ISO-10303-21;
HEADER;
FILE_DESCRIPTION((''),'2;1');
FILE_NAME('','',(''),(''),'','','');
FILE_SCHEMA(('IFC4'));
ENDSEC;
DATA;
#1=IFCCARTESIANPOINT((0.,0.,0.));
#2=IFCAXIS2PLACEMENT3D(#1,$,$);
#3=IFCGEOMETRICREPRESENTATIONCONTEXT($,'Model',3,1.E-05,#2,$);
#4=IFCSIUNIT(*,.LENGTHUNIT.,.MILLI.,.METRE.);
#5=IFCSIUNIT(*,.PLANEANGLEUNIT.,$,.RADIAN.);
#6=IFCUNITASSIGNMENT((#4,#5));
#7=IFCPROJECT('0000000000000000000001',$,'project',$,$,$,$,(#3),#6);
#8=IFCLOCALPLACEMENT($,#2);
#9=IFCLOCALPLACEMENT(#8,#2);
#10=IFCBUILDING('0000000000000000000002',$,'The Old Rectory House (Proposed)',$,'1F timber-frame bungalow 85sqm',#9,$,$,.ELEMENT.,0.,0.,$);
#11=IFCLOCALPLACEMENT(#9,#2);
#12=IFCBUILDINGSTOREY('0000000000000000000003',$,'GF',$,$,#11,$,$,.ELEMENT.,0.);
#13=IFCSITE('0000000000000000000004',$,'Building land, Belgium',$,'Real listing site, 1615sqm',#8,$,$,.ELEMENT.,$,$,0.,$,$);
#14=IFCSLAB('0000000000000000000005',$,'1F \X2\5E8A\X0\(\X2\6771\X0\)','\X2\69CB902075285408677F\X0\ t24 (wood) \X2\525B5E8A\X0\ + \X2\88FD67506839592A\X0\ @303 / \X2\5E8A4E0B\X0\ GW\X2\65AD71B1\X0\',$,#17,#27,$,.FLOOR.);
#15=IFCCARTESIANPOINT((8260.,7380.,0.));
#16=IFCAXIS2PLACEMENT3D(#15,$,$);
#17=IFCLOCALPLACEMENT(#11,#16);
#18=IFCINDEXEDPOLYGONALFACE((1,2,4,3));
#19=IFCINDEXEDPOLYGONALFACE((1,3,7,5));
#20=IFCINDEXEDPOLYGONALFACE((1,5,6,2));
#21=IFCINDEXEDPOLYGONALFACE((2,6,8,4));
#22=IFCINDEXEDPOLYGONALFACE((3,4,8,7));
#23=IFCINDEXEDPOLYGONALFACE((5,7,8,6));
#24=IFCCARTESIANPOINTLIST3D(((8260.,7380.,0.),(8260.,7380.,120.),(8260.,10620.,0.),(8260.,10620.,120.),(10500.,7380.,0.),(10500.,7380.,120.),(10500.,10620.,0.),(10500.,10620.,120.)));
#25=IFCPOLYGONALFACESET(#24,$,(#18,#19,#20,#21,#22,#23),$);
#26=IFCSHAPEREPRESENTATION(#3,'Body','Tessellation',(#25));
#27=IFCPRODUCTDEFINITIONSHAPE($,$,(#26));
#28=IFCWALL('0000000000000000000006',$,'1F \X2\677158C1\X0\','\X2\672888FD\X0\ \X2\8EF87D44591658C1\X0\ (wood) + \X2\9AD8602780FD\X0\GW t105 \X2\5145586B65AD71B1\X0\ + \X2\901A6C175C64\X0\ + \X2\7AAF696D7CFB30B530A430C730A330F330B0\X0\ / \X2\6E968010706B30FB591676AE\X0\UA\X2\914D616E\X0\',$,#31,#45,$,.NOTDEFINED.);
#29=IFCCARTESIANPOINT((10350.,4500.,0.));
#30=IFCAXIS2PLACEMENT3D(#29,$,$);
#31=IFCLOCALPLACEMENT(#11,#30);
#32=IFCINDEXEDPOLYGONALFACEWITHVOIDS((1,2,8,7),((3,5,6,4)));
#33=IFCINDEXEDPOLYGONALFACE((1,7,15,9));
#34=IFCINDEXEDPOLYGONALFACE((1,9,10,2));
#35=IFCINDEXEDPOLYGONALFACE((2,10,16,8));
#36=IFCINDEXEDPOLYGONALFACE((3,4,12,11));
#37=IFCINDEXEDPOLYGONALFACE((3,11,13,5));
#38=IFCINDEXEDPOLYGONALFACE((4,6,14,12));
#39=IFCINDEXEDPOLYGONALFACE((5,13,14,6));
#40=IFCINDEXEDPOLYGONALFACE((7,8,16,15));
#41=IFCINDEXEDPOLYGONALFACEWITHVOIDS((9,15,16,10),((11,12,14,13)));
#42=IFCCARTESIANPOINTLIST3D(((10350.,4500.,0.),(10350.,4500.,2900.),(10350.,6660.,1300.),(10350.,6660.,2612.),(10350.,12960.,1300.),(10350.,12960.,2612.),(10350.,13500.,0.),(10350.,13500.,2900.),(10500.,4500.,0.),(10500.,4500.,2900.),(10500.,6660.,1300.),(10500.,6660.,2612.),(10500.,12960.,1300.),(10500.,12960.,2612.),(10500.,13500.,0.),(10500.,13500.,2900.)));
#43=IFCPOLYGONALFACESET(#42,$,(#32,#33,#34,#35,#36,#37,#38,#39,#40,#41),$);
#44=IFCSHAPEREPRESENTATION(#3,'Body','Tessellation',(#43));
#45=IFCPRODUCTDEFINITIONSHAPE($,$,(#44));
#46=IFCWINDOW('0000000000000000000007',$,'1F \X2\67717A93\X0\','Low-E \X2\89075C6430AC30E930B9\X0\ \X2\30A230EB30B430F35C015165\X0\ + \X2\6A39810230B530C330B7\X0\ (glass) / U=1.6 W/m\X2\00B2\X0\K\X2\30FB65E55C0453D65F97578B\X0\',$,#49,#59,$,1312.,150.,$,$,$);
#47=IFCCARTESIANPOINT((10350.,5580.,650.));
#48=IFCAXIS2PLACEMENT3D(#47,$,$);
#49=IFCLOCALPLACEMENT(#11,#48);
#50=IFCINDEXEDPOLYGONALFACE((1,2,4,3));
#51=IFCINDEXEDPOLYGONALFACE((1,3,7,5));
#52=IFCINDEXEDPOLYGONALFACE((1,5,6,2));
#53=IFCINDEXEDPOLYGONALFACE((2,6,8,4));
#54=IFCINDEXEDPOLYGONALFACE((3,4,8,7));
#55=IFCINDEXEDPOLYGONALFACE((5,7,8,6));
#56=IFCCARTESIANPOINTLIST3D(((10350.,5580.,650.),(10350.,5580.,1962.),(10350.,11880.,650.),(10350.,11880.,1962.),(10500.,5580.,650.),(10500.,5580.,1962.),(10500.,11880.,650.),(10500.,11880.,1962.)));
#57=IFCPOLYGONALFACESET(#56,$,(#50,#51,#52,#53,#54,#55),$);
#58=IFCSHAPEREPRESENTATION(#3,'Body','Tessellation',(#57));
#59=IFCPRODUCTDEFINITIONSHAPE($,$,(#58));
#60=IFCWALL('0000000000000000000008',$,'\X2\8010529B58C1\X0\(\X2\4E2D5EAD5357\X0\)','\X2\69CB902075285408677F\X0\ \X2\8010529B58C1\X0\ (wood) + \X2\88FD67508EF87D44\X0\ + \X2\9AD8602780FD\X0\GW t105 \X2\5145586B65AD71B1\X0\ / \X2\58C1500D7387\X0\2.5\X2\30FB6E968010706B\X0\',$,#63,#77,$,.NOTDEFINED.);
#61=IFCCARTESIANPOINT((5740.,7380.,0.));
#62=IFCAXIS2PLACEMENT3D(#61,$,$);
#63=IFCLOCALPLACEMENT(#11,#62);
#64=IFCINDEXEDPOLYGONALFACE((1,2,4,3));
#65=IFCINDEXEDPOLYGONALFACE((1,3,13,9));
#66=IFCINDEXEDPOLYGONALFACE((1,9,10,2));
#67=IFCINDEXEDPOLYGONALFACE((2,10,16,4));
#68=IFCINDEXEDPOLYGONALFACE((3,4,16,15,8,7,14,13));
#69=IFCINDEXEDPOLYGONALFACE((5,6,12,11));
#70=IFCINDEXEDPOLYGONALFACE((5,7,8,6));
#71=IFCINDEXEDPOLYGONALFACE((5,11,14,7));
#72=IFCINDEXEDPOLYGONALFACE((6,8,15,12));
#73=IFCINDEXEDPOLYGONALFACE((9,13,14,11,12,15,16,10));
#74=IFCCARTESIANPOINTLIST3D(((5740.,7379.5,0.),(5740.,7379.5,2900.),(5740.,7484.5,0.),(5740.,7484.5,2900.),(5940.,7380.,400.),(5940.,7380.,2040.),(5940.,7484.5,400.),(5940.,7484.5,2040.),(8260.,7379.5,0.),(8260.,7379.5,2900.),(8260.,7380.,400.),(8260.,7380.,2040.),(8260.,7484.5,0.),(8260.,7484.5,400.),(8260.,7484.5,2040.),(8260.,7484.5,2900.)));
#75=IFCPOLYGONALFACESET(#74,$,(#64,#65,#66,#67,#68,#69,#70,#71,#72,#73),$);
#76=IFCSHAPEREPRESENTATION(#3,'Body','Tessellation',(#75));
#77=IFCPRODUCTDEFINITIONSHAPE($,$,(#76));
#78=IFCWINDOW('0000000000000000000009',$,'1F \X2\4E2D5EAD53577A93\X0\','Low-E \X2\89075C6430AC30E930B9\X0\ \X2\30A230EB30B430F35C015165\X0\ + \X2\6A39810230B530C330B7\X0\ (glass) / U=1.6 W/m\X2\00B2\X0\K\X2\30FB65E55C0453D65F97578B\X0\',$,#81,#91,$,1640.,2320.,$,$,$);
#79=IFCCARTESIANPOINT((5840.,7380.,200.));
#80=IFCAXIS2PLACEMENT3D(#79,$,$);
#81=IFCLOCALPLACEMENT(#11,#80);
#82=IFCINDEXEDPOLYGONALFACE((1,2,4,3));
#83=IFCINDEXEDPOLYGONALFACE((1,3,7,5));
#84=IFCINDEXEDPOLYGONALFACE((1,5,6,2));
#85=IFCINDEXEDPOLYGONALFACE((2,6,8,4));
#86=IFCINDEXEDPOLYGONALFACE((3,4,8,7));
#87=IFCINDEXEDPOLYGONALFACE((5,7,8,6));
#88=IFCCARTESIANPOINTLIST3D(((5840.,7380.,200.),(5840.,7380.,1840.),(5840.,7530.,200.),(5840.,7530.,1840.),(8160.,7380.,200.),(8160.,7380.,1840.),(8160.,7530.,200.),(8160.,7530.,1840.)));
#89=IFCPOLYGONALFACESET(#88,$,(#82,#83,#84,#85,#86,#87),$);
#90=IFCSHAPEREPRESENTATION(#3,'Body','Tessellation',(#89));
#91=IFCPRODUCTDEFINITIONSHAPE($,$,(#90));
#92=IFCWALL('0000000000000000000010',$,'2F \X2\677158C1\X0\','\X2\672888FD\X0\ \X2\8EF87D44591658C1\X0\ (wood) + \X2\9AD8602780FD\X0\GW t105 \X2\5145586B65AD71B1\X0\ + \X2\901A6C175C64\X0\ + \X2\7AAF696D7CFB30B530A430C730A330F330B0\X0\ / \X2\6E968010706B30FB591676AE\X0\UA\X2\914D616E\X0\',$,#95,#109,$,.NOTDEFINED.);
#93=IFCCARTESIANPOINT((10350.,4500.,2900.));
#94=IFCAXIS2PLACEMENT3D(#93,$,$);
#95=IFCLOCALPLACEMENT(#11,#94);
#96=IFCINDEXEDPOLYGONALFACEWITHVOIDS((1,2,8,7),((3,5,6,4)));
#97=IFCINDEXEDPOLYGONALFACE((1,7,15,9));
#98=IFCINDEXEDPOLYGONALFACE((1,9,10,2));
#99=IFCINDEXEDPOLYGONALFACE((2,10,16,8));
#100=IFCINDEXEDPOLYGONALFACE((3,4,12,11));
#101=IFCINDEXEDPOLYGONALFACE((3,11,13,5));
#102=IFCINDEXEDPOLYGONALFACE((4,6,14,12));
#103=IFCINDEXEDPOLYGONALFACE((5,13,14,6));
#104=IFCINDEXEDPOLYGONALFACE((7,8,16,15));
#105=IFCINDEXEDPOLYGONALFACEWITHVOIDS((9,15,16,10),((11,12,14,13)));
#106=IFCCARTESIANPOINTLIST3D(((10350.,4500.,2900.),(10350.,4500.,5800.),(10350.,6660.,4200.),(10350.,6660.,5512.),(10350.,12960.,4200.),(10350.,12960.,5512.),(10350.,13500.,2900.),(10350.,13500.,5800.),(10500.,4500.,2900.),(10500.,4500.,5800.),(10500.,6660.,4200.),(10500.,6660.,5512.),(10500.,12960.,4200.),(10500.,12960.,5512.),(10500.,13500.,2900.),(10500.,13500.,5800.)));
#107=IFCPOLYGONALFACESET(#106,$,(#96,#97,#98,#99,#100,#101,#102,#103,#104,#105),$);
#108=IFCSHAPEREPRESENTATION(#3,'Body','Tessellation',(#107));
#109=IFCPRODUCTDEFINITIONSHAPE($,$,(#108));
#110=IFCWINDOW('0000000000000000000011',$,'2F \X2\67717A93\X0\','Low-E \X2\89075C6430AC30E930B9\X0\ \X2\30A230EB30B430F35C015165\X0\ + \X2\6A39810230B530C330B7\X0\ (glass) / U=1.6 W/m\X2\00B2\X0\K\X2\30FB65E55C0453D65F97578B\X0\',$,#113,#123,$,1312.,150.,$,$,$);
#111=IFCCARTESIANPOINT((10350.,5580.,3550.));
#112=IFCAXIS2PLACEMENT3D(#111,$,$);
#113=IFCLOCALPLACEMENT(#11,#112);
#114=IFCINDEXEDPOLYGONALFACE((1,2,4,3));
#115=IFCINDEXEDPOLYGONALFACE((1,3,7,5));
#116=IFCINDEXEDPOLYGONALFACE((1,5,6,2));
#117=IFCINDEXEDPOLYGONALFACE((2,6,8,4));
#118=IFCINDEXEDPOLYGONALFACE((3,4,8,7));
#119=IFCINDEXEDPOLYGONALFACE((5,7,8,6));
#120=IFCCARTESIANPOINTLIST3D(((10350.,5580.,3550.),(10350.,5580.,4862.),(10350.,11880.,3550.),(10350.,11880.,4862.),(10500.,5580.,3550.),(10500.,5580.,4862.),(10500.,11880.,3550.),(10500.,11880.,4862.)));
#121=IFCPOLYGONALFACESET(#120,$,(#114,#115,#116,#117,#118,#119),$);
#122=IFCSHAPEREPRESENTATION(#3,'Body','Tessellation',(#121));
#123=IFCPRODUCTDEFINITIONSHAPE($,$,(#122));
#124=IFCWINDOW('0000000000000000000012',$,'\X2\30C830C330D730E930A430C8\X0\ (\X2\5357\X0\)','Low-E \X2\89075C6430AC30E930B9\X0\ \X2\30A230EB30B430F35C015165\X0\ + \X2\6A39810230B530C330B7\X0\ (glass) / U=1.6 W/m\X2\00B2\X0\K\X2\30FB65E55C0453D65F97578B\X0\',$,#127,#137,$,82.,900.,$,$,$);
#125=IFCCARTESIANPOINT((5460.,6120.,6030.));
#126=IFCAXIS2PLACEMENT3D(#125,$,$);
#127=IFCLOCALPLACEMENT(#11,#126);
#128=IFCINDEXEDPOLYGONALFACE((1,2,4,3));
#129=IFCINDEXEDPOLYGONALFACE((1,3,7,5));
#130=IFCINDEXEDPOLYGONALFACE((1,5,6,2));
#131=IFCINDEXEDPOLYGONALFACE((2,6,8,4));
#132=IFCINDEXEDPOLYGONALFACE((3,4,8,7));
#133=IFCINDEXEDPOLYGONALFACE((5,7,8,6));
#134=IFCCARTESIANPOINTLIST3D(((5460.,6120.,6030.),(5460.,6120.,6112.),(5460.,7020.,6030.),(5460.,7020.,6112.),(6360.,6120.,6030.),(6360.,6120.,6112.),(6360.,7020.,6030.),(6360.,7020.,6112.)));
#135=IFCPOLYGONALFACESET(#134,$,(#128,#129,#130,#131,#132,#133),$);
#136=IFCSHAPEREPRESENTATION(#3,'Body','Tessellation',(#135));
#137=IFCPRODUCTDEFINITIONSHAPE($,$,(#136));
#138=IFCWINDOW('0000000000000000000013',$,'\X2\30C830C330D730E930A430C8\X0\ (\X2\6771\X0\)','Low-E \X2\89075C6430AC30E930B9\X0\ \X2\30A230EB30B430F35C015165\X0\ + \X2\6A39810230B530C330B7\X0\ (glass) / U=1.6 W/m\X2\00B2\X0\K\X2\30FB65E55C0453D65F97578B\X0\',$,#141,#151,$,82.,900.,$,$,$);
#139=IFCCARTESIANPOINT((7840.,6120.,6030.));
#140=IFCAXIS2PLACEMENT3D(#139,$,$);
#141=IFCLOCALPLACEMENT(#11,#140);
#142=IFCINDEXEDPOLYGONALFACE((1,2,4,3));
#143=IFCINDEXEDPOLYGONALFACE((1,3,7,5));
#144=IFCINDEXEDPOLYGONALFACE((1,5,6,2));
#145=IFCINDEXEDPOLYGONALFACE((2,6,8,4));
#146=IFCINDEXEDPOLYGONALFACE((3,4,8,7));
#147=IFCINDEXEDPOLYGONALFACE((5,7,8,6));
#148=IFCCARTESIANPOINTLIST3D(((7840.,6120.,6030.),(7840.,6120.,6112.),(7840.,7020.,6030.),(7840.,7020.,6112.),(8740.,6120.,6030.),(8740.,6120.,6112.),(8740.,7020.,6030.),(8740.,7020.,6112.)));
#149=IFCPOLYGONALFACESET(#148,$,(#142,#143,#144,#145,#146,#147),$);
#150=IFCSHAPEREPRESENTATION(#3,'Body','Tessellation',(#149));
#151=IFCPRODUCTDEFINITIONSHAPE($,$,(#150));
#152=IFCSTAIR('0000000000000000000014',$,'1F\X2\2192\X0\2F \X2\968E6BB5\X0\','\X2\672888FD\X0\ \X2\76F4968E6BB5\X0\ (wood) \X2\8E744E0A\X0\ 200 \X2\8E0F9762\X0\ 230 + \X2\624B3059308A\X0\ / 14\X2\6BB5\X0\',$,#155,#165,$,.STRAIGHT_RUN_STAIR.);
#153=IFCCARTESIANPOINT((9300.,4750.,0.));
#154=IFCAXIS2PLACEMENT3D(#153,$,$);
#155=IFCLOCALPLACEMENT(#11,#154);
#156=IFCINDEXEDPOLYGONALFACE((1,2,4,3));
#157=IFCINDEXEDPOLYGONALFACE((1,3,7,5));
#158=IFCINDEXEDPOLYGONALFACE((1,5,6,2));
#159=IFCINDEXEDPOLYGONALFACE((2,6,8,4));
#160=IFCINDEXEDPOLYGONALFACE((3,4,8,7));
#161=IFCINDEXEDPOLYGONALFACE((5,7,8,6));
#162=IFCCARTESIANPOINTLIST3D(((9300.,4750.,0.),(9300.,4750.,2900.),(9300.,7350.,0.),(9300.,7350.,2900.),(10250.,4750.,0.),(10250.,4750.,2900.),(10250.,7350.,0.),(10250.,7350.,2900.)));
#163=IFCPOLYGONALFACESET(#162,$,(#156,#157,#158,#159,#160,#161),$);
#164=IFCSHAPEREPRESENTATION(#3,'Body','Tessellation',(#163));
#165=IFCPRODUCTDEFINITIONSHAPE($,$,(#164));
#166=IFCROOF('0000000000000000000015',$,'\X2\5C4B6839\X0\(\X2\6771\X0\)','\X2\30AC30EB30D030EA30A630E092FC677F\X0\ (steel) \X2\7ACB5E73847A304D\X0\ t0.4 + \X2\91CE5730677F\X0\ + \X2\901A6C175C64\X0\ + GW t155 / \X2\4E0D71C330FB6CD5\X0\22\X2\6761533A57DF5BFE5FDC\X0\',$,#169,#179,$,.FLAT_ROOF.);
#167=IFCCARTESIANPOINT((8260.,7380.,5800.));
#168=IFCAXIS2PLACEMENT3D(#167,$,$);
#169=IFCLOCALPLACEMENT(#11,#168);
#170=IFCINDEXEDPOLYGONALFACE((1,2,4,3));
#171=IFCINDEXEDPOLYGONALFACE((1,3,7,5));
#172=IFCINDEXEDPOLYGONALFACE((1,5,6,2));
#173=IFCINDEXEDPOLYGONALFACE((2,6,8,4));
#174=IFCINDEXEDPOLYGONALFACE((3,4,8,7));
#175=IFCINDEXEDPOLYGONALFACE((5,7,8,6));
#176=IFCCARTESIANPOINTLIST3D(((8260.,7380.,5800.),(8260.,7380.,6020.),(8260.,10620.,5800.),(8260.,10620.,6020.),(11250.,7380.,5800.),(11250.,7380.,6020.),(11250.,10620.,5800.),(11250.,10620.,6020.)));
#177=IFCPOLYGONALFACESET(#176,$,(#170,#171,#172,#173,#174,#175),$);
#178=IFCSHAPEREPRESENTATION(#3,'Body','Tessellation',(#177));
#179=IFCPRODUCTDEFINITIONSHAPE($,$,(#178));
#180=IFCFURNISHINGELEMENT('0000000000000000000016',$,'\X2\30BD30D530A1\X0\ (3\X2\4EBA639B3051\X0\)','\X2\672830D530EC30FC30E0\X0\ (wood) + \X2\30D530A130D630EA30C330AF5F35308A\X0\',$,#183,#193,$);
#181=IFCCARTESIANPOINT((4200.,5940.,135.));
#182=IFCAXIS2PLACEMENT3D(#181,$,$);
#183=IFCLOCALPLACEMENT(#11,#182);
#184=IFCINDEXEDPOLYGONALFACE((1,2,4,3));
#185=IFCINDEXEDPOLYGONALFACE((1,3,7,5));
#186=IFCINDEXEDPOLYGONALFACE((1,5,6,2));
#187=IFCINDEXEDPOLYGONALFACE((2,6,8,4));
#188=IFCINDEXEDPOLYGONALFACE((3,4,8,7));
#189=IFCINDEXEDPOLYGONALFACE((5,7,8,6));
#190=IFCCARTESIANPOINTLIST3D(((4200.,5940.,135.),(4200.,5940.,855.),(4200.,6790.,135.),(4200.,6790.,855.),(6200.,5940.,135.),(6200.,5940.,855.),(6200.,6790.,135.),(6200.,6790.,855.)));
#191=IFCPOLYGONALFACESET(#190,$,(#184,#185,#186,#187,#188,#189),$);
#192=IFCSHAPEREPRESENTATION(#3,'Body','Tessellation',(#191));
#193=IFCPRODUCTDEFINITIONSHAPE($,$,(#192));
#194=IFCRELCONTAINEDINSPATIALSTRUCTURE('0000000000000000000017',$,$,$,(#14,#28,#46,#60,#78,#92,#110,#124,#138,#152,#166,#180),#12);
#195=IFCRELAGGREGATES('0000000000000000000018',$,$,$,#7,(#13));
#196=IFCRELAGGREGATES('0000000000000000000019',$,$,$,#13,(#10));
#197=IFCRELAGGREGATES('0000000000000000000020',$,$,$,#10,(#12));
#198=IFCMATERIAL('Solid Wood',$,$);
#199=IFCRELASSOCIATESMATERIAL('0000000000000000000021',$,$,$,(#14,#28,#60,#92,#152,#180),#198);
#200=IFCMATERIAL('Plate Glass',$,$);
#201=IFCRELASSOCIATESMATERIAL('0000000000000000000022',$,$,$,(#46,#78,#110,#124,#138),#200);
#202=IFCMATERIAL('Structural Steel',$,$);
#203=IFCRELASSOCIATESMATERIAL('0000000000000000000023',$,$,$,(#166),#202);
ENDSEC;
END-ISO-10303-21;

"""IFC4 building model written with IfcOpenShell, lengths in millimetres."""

from ifc_helpers import new_model, si_unit, frame, frame_2d, origin, place, context, project, spatial, rectangle, extrude, material, element, fill, save


model = new_model("IFC4")

# Units and contexts
model_context = context("Model", 3, precision=1e-05, world=origin())
ifc_project = project(units=[si_unit("LENGTHUNIT", "METRE", prefix="MILLI"), si_unit("PLANEANGLEUNIT", "RADIAN")], contexts=[model_context])

# Site, building, storey
site_placement = place(None, origin())
site = spatial("IfcSite", under=ifc_project, at=site_placement, Name="Building land, Belgium", ObjectType="Real listing site, 1615sqm", CompositionType="ELEMENT", RefElevation=0.0)
building_placement = place(site_placement, origin())
building = spatial("IfcBuilding", under=site, at=building_placement, Name="The Old Rectory House (Proposed)", ObjectType="1F timber-frame bungalow 85sqm", CompositionType="ELEMENT", ElevationOfRefHeight=0.0, ElevationOfTerrain=0.0)
storey_placement = place(building_placement, origin())
storey = spatial("IfcBuildingStorey", under=building, at=storey_placement, Name="GF", CompositionType="ELEMENT", Elevation=0.0)

# Slab
ifc_material_1 = material(Name="Solid Wood")
slab_placement = place(storey_placement, frame((8260.0, 7380.0, 0.0)))
element("IfcSlab", 1, at=slab_placement, inside=storey, material=ifc_material_1, Name="1F 床(東)", Description="構造用合板 t24 (wood) 剛床 + 製材根太 @303 / 床下 GW断熱", PredefinedType="FLOOR", context=model_context, shape_type="SweptSolid", body=[
    extrude(rectangle(XDim=2240.0, YDim=3240.0, at=frame_2d((1120.0, 1620.0))), frame((8260.0, 7380.0, 0.0)), (0.0, 0.0, 1.0), 120.0),
])

# Walls, openings, windows
wall_1_placement = place(storey_placement, frame((10350.0, 4500.0, 0.0)))
wall_1 = element("IfcWall", 2, at=wall_1_placement, inside=storey, material=ifc_material_1, Name="1F 東壁", Description="木製 軸組外壁 (wood) + 高性能GW t105 充填断熱 + 通気層 + 窯業系サイディング / 準耐火・外皮UA配慮", PredefinedType="NOTDEFINED", context=model_context, shape_type="SweptSolid", body=[
    extrude(rectangle(XDim=150.0, YDim=9000.0, at=frame_2d((75.0, 4500.0))), frame((10350.0, 4500.0, 0.0)), (0.0, 0.0, 1.0), 2900.0),
])
opening_1_placement = place(storey_placement, frame((10350.0, 5580.0, 650.0)))
opening_1 = element("IfcOpeningElement", 3, at=opening_1_placement, cuts=wall_1, PredefinedType="NOTDEFINED", context=model_context, shape_type="SweptSolid", body=[
    extrude(rectangle(XDim=150.0, YDim=6300.0, at=frame_2d((75.0, 3150.0))), frame((10350.0, 5580.0, 650.0)), (0.0, 0.0, 1.0), 1312.0),
])
ifc_material_2 = material(Name="Plate Glass")
window_1_placement = place(storey_placement, frame((10350.0, 5580.0, 650.0)))
window_1 = element("IfcWindow", 4, at=window_1_placement, inside=storey, material=ifc_material_2, Name="1F 東窓", Description="Low-E 複層ガラス アルゴン封入 + 樹脂サッシ (glass) / U=1.6 W/m²K・日射取得型", OverallHeight=1312.0, OverallWidth=150.0, context=model_context, shape_type="SweptSolid", body=[
    extrude(rectangle(XDim=150.0, YDim=6300.0, at=frame_2d((75.0, 3150.0))), frame((10350.0, 5580.0, 650.0)), (0.0, 0.0, 1.0), 1312.0),
])
fill(opening_1, window_1)
wall_2_placement = place(storey_placement, frame((5740.0, 7380.0, 0.0)))
wall_2 = element("IfcWall", 5, at=wall_2_placement, inside=storey, material=ifc_material_1, Name="耐力壁(中庭南)", Description="構造用合板 耐力壁 (wood) + 製材軸組 + 高性能GW t105 充填断熱 / 壁倍率2.5・準耐火", PredefinedType="NOTDEFINED", context=model_context, shape_type="SweptSolid", body=[
    extrude(rectangle(XDim=2520.0, YDim=105.0, at=frame_2d((1260.0, 52.0))), frame((5740.0, 7380.0, 0.0)), (0.0, 0.0, 1.0), 2900.0),
])
opening_2_placement = place(storey_placement, frame((5840.0, 7380.0, 200.0)))
opening_2 = element("IfcOpeningElement", 6, at=opening_2_placement, cuts=wall_2, PredefinedType="NOTDEFINED", context=model_context, shape_type="SweptSolid", body=[
    extrude(rectangle(XDim=2320.0, YDim=150.0, at=frame_2d((1160.0, 75.0))), frame((5840.0, 7380.0, 200.0)), (0.0, 0.0, 1.0), 1640.0),
])
window_2_placement = place(storey_placement, frame((5840.0, 7380.0, 200.0)))
window_2 = element("IfcWindow", 7, at=window_2_placement, inside=storey, material=ifc_material_2, Name="1F 中庭南窓", Description="Low-E 複層ガラス アルゴン封入 + 樹脂サッシ (glass) / U=1.6 W/m²K・日射取得型", OverallHeight=1640.0, OverallWidth=2320.0, context=model_context, shape_type="SweptSolid", body=[
    extrude(rectangle(XDim=2320.0, YDim=150.0, at=frame_2d((1160.0, 75.0))), frame((5840.0, 7380.0, 200.0)), (0.0, 0.0, 1.0), 1640.0),
])
fill(opening_2, window_2)

# Wall, opening, window
wall_3_placement = place(storey_placement, frame((10350.0, 4500.0, 2900.0)))
wall_3 = element("IfcWall", 8, at=wall_3_placement, inside=storey, material=ifc_material_1, Name="2F 東壁", Description="木製 軸組外壁 (wood) + 高性能GW t105 充填断熱 + 通気層 + 窯業系サイディング / 準耐火・外皮UA配慮", PredefinedType="NOTDEFINED", context=model_context, shape_type="SweptSolid", body=[
    extrude(rectangle(XDim=150.0, YDim=9000.0, at=frame_2d((75.0, 4500.0))), frame((10350.0, 4500.0, 2900.0)), (0.0, 0.0, 1.0), 2900.0),
])
opening_3_placement = place(storey_placement, frame((10350.0, 5580.0, 3550.0)))
opening_3 = element("IfcOpeningElement", 9, at=opening_3_placement, cuts=wall_3, PredefinedType="NOTDEFINED", context=model_context, shape_type="SweptSolid", body=[
    extrude(rectangle(XDim=150.0, YDim=6300.0, at=frame_2d((75.0, 3150.0))), frame((10350.0, 5580.0, 3550.0)), (0.0, 0.0, 1.0), 1312.0),
])
window_3_placement = place(storey_placement, frame((10350.0, 5580.0, 3550.0)))
window_3 = element("IfcWindow", 10, at=window_3_placement, inside=storey, material=ifc_material_2, Name="2F 東窓", Description="Low-E 複層ガラス アルゴン封入 + 樹脂サッシ (glass) / U=1.6 W/m²K・日射取得型", OverallHeight=1312.0, OverallWidth=150.0, context=model_context, shape_type="SweptSolid", body=[
    extrude(rectangle(XDim=150.0, YDim=6300.0, at=frame_2d((75.0, 3150.0))), frame((10350.0, 5580.0, 3550.0)), (0.0, 0.0, 1.0), 1312.0),
])
fill(opening_3, window_3)

# Windows
window_4_placement = place(storey_placement, frame((5460.0, 6120.0, 6030.0)))
element("IfcWindow", 11, at=window_4_placement, inside=storey, material=ifc_material_2, Name="トップライト (南)", Description="Low-E 複層ガラス アルゴン封入 + 樹脂サッシ (glass) / U=1.6 W/m²K・日射取得型", OverallHeight=82.0, OverallWidth=900.0, context=model_context, shape_type="SweptSolid", body=[
    extrude(rectangle(XDim=900.0, YDim=900.0, at=frame_2d((450.0, 450.0))), frame((5460.0, 6120.0, 6030.0)), (0.0, 0.0, 1.0), 82.0),
])
window_5_placement = place(storey_placement, frame((7840.0, 6120.0, 6030.0)))
element("IfcWindow", 12, at=window_5_placement, inside=storey, material=ifc_material_2, Name="トップライト (東)", Description="Low-E 複層ガラス アルゴン封入 + 樹脂サッシ (glass) / U=1.6 W/m²K・日射取得型", OverallHeight=82.0, OverallWidth=900.0, context=model_context, shape_type="SweptSolid", body=[
    extrude(rectangle(XDim=900.0, YDim=900.0, at=frame_2d((450.0, 450.0))), frame((7840.0, 6120.0, 6030.0)), (0.0, 0.0, 1.0), 82.0),
])

# Stair
stair_placement = place(storey_placement, frame((9300.0, 4750.0, 0.0)))
element("IfcStair", 13, at=stair_placement, inside=storey, material=ifc_material_1, Name="1F→2F 階段", Description="木製 直階段 (wood) 蹴上 200 踏面 230 + 手すり / 14段", PredefinedType="STRAIGHT_RUN_STAIR", context=model_context, shape_type="SweptSolid", body=[
    extrude(rectangle(XDim=950.0, YDim=2600.0, at=frame_2d((475.0, 1300.0))), frame((9300.0, 4750.0, 0.0)), (0.0, 0.0, 1.0), 2900.0),
])

# Roof
ifc_material_3 = material(Name="Structural Steel")
roof_placement = place(storey_placement, frame((8260.0, 7380.0, 5800.0)))
element("IfcRoof", 14, at=roof_placement, inside=storey, material=ifc_material_3, Name="屋根(東)", Description="ガルバリウム鋼板 (steel) 立平葺き t0.4 + 野地板 + 通気層 + GW t155 / 不燃・法22条区域対応", PredefinedType="FLAT_ROOF", context=model_context, shape_type="SweptSolid", body=[
    extrude(rectangle(XDim=2990.0, YDim=3240.0, at=frame_2d((1495.0, 1620.0))), frame((8260.0, 7380.0, 5800.0)), (0.0, 0.0, 1.0), 220.0),
])

# Furnishing element
furnishing_1_placement = place(storey_placement, frame((4200.0, 5940.0, 135.0)))
element("IfcFurnishingElement", 15, at=furnishing_1_placement, inside=storey, material=ifc_material_1, Name="ソファ (3人掛け)", Description="木フレーム (wood) + ファブリック張り", context=model_context, shape_type="SweptSolid", body=[
    extrude(rectangle(XDim=2000.0, YDim=850.0, at=frame_2d((1000.0, 425.0))), frame((4200.0, 5940.0, 135.0)), (0.0, 0.0, 1.0), 720.0),
])

save(model, "model.ifc")
